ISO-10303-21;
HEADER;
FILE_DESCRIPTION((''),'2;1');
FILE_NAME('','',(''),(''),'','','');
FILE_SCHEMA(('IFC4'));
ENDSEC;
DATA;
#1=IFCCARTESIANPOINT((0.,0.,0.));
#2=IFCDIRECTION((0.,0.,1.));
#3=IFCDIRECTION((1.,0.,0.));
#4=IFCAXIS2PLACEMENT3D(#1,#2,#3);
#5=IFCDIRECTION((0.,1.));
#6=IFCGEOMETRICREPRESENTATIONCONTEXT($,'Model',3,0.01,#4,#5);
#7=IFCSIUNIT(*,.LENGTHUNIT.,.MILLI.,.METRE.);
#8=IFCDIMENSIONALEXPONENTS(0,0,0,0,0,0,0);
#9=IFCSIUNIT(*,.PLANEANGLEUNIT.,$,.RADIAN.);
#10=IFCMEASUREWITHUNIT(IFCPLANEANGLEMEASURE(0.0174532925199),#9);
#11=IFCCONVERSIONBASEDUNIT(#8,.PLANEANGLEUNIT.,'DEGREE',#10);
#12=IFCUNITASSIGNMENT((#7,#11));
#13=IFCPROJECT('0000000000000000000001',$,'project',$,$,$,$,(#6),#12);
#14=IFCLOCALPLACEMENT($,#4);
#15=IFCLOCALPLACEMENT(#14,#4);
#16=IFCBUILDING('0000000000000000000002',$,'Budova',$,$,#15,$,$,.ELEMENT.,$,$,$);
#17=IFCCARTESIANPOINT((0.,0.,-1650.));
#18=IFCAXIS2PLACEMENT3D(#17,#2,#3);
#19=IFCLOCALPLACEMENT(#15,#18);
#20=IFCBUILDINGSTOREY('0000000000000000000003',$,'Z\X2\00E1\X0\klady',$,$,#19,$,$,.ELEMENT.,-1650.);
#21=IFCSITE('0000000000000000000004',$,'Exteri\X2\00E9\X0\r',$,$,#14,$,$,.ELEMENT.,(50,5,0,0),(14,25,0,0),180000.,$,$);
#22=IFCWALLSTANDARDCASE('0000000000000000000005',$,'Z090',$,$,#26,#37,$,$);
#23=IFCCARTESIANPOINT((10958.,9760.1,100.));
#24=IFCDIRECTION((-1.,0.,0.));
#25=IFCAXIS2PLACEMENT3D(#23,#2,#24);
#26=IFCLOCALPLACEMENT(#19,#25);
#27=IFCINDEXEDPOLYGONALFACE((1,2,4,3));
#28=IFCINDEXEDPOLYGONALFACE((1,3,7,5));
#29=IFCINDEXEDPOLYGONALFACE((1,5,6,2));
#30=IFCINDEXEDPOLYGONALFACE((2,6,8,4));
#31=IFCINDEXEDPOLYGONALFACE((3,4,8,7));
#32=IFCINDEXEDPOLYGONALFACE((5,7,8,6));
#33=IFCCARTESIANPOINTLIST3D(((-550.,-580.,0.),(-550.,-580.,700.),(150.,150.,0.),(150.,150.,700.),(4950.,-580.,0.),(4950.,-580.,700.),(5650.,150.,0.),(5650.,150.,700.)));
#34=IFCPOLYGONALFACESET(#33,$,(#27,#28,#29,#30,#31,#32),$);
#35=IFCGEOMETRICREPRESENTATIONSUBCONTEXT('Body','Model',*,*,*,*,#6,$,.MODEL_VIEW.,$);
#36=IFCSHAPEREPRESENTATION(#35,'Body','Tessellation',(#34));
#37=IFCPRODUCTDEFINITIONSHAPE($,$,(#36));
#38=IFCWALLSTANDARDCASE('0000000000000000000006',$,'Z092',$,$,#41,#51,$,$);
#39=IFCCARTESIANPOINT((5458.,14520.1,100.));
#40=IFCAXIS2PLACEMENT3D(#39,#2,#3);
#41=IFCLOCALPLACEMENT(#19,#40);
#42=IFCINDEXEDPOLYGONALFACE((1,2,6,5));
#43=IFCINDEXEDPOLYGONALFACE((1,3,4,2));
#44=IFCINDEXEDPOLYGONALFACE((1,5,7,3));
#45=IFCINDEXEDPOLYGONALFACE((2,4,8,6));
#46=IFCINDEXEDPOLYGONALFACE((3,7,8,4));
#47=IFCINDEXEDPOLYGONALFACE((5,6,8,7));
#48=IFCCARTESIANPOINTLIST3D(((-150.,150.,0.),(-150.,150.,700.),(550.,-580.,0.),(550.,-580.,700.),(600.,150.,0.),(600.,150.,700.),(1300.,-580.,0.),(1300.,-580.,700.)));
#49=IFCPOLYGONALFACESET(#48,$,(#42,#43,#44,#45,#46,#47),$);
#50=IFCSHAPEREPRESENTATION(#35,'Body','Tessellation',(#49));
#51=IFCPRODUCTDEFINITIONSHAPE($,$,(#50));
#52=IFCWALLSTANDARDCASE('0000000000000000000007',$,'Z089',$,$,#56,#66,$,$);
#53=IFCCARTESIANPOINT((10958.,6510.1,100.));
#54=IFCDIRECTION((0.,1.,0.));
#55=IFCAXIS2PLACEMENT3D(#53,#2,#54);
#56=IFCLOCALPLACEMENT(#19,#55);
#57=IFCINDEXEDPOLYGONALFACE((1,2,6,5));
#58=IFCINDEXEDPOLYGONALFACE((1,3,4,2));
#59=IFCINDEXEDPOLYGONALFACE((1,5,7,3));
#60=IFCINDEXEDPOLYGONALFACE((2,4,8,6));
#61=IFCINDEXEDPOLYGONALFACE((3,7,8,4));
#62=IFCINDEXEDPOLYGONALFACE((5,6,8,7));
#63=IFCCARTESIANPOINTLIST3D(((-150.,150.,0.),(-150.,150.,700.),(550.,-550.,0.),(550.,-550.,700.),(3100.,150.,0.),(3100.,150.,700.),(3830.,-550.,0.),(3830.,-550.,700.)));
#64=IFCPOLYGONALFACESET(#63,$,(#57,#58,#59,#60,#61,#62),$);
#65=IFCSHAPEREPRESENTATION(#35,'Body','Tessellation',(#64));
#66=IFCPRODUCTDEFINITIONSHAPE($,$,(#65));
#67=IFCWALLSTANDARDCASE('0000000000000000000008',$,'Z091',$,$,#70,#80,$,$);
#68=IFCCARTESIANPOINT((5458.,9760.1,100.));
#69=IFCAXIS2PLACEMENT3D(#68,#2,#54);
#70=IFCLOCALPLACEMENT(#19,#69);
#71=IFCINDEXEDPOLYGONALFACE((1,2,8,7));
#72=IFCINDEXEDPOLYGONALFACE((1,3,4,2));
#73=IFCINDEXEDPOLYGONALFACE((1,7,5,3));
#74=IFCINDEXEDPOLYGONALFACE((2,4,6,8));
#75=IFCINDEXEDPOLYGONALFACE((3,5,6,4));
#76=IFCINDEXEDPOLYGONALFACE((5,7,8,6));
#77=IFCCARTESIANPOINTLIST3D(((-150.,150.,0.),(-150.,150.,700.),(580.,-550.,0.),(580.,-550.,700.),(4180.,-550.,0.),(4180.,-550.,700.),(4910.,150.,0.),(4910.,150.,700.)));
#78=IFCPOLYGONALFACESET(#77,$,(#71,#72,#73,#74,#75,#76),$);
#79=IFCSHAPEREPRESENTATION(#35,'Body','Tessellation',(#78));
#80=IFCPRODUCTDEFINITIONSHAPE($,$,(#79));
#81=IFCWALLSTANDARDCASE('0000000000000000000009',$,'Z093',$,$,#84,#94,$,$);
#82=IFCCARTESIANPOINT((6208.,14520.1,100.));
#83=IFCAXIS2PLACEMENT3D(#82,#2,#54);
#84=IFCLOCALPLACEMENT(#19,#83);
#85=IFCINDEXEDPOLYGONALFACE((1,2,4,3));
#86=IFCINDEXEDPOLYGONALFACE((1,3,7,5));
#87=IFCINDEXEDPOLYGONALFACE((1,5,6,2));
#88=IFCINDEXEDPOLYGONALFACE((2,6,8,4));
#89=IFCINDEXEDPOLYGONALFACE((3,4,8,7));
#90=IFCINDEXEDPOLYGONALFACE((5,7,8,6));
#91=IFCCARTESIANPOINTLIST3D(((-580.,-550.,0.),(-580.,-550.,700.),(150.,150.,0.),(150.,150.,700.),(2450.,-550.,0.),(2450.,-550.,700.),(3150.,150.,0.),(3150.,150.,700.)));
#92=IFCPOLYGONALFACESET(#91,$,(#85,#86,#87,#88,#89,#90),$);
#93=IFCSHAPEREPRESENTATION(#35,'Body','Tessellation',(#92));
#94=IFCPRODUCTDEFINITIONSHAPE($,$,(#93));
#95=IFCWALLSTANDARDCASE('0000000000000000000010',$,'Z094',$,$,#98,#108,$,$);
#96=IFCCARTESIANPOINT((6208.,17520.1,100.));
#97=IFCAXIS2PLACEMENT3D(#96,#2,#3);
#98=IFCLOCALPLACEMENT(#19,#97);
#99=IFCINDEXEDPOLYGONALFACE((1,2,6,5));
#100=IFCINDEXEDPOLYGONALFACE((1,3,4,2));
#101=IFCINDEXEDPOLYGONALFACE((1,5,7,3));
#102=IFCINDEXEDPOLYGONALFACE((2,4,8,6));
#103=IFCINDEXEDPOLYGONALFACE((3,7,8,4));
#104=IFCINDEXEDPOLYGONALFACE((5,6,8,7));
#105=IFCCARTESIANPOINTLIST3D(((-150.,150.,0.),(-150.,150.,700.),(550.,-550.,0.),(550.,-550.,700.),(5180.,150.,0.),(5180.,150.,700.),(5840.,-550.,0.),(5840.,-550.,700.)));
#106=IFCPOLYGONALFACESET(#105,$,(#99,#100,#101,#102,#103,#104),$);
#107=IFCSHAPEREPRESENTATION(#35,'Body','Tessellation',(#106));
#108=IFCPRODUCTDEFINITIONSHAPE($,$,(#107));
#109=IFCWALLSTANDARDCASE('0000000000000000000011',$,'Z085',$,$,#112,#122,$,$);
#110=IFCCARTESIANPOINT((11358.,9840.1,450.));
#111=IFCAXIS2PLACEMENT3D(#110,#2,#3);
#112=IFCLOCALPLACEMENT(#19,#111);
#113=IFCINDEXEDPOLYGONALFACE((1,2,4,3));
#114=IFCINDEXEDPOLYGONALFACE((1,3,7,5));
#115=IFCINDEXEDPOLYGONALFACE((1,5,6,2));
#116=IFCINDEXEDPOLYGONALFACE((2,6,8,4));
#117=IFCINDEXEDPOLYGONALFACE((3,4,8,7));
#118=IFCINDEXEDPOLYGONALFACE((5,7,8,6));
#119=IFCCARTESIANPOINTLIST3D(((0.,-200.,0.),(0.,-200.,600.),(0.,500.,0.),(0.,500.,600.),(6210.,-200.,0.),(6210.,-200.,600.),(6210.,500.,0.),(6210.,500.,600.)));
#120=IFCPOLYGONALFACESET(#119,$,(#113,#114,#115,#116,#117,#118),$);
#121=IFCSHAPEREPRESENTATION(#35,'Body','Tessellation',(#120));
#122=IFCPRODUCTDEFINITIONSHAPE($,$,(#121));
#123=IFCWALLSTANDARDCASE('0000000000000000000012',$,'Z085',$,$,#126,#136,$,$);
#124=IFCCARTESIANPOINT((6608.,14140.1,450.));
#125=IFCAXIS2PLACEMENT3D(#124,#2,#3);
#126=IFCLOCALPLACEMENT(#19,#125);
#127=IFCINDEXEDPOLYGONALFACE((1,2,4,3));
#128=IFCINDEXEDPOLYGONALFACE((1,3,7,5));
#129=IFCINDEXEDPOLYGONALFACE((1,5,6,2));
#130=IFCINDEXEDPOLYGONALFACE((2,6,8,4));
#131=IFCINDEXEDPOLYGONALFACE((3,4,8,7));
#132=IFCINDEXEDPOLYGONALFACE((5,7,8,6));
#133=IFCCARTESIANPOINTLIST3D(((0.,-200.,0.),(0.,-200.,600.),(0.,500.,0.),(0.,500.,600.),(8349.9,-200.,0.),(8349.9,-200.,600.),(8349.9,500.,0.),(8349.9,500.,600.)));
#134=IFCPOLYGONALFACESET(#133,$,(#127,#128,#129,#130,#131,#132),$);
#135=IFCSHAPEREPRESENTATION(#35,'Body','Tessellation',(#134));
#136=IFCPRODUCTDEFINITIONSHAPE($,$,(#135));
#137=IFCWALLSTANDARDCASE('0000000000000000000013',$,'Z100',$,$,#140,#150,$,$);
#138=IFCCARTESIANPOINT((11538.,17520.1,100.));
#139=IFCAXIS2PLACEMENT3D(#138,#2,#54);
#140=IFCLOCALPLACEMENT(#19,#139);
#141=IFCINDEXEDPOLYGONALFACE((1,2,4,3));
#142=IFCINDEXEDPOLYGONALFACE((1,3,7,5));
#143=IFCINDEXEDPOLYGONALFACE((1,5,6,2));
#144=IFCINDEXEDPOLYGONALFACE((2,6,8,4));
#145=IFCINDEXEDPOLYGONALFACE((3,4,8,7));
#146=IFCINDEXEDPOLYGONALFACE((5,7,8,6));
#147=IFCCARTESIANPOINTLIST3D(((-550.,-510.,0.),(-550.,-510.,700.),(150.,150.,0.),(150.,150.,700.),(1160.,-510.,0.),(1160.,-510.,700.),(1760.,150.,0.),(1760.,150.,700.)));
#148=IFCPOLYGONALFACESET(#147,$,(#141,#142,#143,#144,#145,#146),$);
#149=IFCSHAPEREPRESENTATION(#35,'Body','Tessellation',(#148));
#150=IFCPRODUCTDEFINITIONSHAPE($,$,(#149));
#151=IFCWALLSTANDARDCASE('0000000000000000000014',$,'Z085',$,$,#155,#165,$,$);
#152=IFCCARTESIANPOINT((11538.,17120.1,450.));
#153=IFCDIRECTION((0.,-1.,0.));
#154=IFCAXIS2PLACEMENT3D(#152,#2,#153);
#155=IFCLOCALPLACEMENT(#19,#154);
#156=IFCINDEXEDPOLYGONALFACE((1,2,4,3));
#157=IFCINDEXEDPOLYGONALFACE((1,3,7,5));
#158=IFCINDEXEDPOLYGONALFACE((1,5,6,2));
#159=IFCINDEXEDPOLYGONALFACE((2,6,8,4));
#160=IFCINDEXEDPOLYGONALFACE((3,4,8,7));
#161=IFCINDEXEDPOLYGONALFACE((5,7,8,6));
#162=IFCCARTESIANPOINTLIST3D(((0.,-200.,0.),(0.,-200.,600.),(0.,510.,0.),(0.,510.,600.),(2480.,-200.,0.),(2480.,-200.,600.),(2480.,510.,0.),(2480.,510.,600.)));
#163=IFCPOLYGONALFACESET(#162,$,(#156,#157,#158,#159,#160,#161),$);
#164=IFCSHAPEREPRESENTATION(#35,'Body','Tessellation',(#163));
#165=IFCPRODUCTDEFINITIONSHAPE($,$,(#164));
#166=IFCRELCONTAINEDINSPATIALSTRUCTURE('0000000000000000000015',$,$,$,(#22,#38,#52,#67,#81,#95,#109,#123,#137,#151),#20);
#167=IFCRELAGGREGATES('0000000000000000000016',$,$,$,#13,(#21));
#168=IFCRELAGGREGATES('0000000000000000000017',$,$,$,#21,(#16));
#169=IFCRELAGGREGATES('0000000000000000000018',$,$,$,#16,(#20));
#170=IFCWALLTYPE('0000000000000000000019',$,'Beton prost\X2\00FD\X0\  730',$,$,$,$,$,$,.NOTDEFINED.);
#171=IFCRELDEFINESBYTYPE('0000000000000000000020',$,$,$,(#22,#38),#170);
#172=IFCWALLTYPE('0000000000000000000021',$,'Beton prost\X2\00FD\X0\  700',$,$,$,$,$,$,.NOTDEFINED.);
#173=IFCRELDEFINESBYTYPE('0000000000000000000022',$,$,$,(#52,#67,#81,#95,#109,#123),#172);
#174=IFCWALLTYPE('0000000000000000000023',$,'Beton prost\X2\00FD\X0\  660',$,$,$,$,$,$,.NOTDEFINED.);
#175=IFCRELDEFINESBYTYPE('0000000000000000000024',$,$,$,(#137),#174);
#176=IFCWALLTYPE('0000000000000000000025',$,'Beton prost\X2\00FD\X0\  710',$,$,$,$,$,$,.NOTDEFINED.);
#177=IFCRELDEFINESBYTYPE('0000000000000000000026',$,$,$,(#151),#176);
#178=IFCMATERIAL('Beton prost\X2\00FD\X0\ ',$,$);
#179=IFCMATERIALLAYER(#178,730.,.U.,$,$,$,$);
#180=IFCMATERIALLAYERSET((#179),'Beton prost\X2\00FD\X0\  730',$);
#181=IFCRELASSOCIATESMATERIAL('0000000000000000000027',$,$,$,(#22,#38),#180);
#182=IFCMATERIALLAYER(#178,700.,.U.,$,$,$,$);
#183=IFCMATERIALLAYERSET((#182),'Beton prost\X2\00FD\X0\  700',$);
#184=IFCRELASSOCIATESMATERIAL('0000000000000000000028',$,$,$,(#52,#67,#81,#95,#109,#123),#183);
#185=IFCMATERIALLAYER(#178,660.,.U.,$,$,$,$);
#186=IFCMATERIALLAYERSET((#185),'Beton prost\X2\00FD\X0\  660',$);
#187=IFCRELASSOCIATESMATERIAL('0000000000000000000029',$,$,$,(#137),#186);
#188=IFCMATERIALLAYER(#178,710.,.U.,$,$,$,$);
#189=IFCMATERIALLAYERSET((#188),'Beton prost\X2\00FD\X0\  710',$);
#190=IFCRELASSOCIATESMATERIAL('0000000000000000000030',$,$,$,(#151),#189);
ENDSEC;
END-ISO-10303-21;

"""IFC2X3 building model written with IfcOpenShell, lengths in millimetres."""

from ifc_helpers import new_model, entity, si_unit, converted_unit, direction, frame, origin_with_axes, place, context, subcontext, project, spatial, polyline, outline, extrude, material, layer, layer_set, layer_usage, type_object, element, save


model = new_model("IFC2X3")

# Units and contexts
model_context = context("Model", 3, precision=0.01, world=origin_with_axes(), true_north=direction((0.0, 1.0)))
body_context = subcontext(model_context, "Body", "Model", "MODEL_VIEW")
ifc_project = project(units=[si_unit("LENGTHUNIT", "METRE", prefix="MILLI"), converted_unit("PLANEANGLEUNIT", "DEGREE", entity("IfcPlaneAngleMeasure", 0.0174532925199), si_unit("PLANEANGLEUNIT", "RADIAN"), dimensions=[0, 0, 0, 0, 0, 0, 0])], contexts=[model_context])

# Site, building, storey
site_placement = place(None, origin_with_axes())
site = spatial("IfcSite", under=ifc_project, at=site_placement, Name="Exteriér", CompositionType="ELEMENT", RefLatitude=(50, 5, 0, 0), RefLongitude=(14, 25, 0, 0), RefElevation=180000.0)
building_placement = place(site_placement, origin_with_axes())
building = spatial("IfcBuilding", under=site, at=building_placement, Name="Budova", CompositionType="ELEMENT")
storey_placement = place(building_placement, frame((0.0, 0.0, -1650.0), z_axis=(0.0, 0.0, 1.0), x_axis=(1.0, 0.0, 0.0)))
storey = spatial("IfcBuildingStorey", under=building, at=storey_placement, Name="Základy", CompositionType="ELEMENT", Elevation=-1650.0)

# Shared definitions
ifc_material_1 = material(Name="Beton prostý ")

# Walls
ifc_layer_1 = layer(ifc_material_1, 730.0, ventilated="UNKNOWN")
ifc_layer_set_1 = layer_set([ifc_layer_1], Name="Beton prostý  730")
ifc_layer_usage_1 = layer_usage(ifc_layer_set_1, "AXIS2", "POSITIVE", -580.0)
wall_type_1 = type_object("IfcWallType", Name="Beton prostý  730", PredefinedType="NOTDEFINED")
wall_1_placement = place(storey_placement, frame((10958.0, 9760.1, 100.0), z_axis=(0.0, 0.0, 1.0), x_axis=(-1.0, 0.0, 0.0)))
element("IfcWallStandardCase", 1, at=wall_1_placement, inside=storey, type_object=wall_type_1, material=ifc_layer_usage_1, Name="Z090", context=body_context, shape_type="SweptSolid", body=[
    extrude(outline(polyline([(-550.0, -580.0), (4950.0, -580.0), (5650.0, 150.0), (150.0, 150.0), (-550.0, -580.0)])), origin_with_axes(), (0.0, 0.0, 1.0), 700.0),
])
ifc_layer_usage_2 = layer_usage(ifc_layer_set_1, "AXIS2", "POSITIVE", -580.0)
wall_2_placement = place(storey_placement, frame((5458.0, 14520.1, 100.0), z_axis=(0.0, 0.0, 1.0), x_axis=(1.0, 0.0, 0.0)))
element("IfcWallStandardCase", 2, at=wall_2_placement, inside=storey, type_object=wall_type_1, material=ifc_layer_usage_2, Name="Z092", context=body_context, shape_type="SweptSolid", body=[
    extrude(outline(polyline([(550.0, -580.0), (1300.0, -580.0), (600.0, 150.0), (-150.0, 150.0), (550.0, -580.0)])), origin_with_axes(), (0.0, 0.0, 1.0), 700.0),
])
ifc_layer_2 = layer(ifc_material_1, 700.0, ventilated="UNKNOWN")
ifc_layer_set_2 = layer_set([ifc_layer_2], Name="Beton prostý  700")
ifc_layer_usage_3 = layer_usage(ifc_layer_set_2, "AXIS2", "POSITIVE", -550.0)
wall_type_2 = type_object("IfcWallType", Name="Beton prostý  700", PredefinedType="NOTDEFINED")
wall_3_placement = place(storey_placement, frame((10958.0, 6510.1, 100.0), z_axis=(0.0, 0.0, 1.0), x_axis=(0.0, 1.0, 0.0)))
element("IfcWallStandardCase", 3, at=wall_3_placement, inside=storey, type_object=wall_type_2, material=ifc_layer_usage_3, Name="Z089", context=body_context, shape_type="SweptSolid", body=[
    extrude(outline(polyline([(550.0, -550.0), (3830.0, -550.0), (3100.0, 150.0), (-150.0, 150.0), (550.0, -550.0)])), origin_with_axes(), (0.0, 0.0, 1.0), 700.0),
])
ifc_layer_usage_4 = layer_usage(ifc_layer_set_2, "AXIS2", "POSITIVE", -550.0)
wall_4_placement = place(storey_placement, frame((5458.0, 9760.1, 100.0), z_axis=(0.0, 0.0, 1.0), x_axis=(0.0, 1.0, 0.0)))
element("IfcWallStandardCase", 4, at=wall_4_placement, inside=storey, type_object=wall_type_2, material=ifc_layer_usage_4, Name="Z091", context=body_context, shape_type="SweptSolid", body=[
    extrude(outline(polyline([(580.0, -550.0), (4180.0, -550.0), (4910.0, 150.0), (-150.0, 150.0), (580.0, -550.0)])), origin_with_axes(), (0.0, 0.0, 1.0), 700.0),
])
ifc_layer_usage_5 = layer_usage(ifc_layer_set_2, "AXIS2", "POSITIVE", -550.0)
wall_5_placement = place(storey_placement, frame((6208.0, 14520.1, 100.0), z_axis=(0.0, 0.0, 1.0), x_axis=(0.0, 1.0, 0.0)))
element("IfcWallStandardCase", 5, at=wall_5_placement, inside=storey, type_object=wall_type_2, material=ifc_layer_usage_5, Name="Z093", context=body_context, shape_type="SweptSolid", body=[
    extrude(outline(polyline([(-580.0, -550.0), (2450.0, -550.0), (3150.0, 150.0), (150.0, 150.0), (-580.0, -550.0)])), origin_with_axes(), (0.0, 0.0, 1.0), 700.0),
])
ifc_layer_usage_6 = layer_usage(ifc_layer_set_2, "AXIS2", "POSITIVE", -550.0)
wall_6_placement = place(storey_placement, frame((6208.0, 17520.1, 100.0), z_axis=(0.0, 0.0, 1.0), x_axis=(1.0, 0.0, 0.0)))
element("IfcWallStandardCase", 6, at=wall_6_placement, inside=storey, type_object=wall_type_2, material=ifc_layer_usage_6, Name="Z094", context=body_context, shape_type="SweptSolid", body=[
    extrude(outline(polyline([(550.0, -550.0), (5840.0, -550.0), (5180.0, 150.0), (-150.0, 150.0), (550.0, -550.0)])), origin_with_axes(), (0.0, 0.0, 1.0), 700.0),
])
ifc_layer_usage_7 = layer_usage(ifc_layer_set_2, "AXIS2", "POSITIVE", -200.0)
wall_7_placement = place(storey_placement, frame((11358.0, 9840.1, 450.0), z_axis=(0.0, 0.0, 1.0), x_axis=(1.0, 0.0, 0.0)))
element("IfcWallStandardCase", 7, at=wall_7_placement, inside=storey, type_object=wall_type_2, material=ifc_layer_usage_7, Name="Z085", context=body_context, shape_type="SweptSolid", body=[
    extrude(outline(polyline([(0.0, -200.0), (6210.0, -200.0), (6210.0, 500.0), (0.0, 500.0), (0.0, -200.0)])), origin_with_axes(), (0.0, 0.0, 1.0), 600.0),
])
ifc_layer_usage_8 = layer_usage(ifc_layer_set_2, "AXIS2", "POSITIVE", -200.0)
wall_8_placement = place(storey_placement, frame((6608.0, 14140.1, 450.0), z_axis=(0.0, 0.0, 1.0), x_axis=(1.0, 0.0, 0.0)))
element("IfcWallStandardCase", 8, at=wall_8_placement, inside=storey, type_object=wall_type_2, material=ifc_layer_usage_8, Name="Z085", context=body_context, shape_type="SweptSolid", body=[
    extrude(outline(polyline([(0.0, -200.0), (8349.9, -200.0), (8349.9, 500.0), (0.0, 500.0), (0.0, -200.0)])), origin_with_axes(), (0.0, 0.0, 1.0), 600.0),
])
ifc_layer_3 = layer(ifc_material_1, 660.0, ventilated="UNKNOWN")
ifc_layer_set_3 = layer_set([ifc_layer_3], Name="Beton prostý  660")
ifc_layer_usage_9 = layer_usage(ifc_layer_set_3, "AXIS2", "POSITIVE", -510.0)
wall_type_3 = type_object("IfcWallType", Name="Beton prostý  660", PredefinedType="NOTDEFINED")
wall_9_placement = place(storey_placement, frame((11538.0, 17520.1, 100.0), z_axis=(0.0, 0.0, 1.0), x_axis=(0.0, 1.0, 0.0)))
element("IfcWallStandardCase", 9, at=wall_9_placement, inside=storey, type_object=wall_type_3, material=ifc_layer_usage_9, Name="Z100", context=body_context, shape_type="SweptSolid", body=[
    extrude(outline(polyline([(-550.0, -510.0), (1160.0, -510.0), (1760.0, 150.0), (150.0, 150.0), (-550.0, -510.0)])), origin_with_axes(), (0.0, 0.0, 1.0), 700.0),
])
ifc_layer_4 = layer(ifc_material_1, 710.0, ventilated="UNKNOWN")
ifc_layer_set_4 = layer_set([ifc_layer_4], Name="Beton prostý  710")
ifc_layer_usage_10 = layer_usage(ifc_layer_set_4, "AXIS2", "POSITIVE", -200.0)
wall_type_4 = type_object("IfcWallType", Name="Beton prostý  710", PredefinedType="NOTDEFINED")
wall_10_placement = place(storey_placement, frame((11538.0, 17120.1, 450.0), z_axis=(0.0, 0.0, 1.0), x_axis=(0.0, -1.0, 0.0)))
element("IfcWallStandardCase", 10, at=wall_10_placement, inside=storey, type_object=wall_type_4, material=ifc_layer_usage_10, Name="Z085", context=body_context, shape_type="SweptSolid", body=[
    extrude(outline(polyline([(0.0, -200.0), (2480.0, -200.0), (2480.0, 510.0), (0.0, 510.0), (0.0, -200.0)])), origin_with_axes(), (0.0, 0.0, 1.0), 600.0),
])

save(model, "model.ifc")
